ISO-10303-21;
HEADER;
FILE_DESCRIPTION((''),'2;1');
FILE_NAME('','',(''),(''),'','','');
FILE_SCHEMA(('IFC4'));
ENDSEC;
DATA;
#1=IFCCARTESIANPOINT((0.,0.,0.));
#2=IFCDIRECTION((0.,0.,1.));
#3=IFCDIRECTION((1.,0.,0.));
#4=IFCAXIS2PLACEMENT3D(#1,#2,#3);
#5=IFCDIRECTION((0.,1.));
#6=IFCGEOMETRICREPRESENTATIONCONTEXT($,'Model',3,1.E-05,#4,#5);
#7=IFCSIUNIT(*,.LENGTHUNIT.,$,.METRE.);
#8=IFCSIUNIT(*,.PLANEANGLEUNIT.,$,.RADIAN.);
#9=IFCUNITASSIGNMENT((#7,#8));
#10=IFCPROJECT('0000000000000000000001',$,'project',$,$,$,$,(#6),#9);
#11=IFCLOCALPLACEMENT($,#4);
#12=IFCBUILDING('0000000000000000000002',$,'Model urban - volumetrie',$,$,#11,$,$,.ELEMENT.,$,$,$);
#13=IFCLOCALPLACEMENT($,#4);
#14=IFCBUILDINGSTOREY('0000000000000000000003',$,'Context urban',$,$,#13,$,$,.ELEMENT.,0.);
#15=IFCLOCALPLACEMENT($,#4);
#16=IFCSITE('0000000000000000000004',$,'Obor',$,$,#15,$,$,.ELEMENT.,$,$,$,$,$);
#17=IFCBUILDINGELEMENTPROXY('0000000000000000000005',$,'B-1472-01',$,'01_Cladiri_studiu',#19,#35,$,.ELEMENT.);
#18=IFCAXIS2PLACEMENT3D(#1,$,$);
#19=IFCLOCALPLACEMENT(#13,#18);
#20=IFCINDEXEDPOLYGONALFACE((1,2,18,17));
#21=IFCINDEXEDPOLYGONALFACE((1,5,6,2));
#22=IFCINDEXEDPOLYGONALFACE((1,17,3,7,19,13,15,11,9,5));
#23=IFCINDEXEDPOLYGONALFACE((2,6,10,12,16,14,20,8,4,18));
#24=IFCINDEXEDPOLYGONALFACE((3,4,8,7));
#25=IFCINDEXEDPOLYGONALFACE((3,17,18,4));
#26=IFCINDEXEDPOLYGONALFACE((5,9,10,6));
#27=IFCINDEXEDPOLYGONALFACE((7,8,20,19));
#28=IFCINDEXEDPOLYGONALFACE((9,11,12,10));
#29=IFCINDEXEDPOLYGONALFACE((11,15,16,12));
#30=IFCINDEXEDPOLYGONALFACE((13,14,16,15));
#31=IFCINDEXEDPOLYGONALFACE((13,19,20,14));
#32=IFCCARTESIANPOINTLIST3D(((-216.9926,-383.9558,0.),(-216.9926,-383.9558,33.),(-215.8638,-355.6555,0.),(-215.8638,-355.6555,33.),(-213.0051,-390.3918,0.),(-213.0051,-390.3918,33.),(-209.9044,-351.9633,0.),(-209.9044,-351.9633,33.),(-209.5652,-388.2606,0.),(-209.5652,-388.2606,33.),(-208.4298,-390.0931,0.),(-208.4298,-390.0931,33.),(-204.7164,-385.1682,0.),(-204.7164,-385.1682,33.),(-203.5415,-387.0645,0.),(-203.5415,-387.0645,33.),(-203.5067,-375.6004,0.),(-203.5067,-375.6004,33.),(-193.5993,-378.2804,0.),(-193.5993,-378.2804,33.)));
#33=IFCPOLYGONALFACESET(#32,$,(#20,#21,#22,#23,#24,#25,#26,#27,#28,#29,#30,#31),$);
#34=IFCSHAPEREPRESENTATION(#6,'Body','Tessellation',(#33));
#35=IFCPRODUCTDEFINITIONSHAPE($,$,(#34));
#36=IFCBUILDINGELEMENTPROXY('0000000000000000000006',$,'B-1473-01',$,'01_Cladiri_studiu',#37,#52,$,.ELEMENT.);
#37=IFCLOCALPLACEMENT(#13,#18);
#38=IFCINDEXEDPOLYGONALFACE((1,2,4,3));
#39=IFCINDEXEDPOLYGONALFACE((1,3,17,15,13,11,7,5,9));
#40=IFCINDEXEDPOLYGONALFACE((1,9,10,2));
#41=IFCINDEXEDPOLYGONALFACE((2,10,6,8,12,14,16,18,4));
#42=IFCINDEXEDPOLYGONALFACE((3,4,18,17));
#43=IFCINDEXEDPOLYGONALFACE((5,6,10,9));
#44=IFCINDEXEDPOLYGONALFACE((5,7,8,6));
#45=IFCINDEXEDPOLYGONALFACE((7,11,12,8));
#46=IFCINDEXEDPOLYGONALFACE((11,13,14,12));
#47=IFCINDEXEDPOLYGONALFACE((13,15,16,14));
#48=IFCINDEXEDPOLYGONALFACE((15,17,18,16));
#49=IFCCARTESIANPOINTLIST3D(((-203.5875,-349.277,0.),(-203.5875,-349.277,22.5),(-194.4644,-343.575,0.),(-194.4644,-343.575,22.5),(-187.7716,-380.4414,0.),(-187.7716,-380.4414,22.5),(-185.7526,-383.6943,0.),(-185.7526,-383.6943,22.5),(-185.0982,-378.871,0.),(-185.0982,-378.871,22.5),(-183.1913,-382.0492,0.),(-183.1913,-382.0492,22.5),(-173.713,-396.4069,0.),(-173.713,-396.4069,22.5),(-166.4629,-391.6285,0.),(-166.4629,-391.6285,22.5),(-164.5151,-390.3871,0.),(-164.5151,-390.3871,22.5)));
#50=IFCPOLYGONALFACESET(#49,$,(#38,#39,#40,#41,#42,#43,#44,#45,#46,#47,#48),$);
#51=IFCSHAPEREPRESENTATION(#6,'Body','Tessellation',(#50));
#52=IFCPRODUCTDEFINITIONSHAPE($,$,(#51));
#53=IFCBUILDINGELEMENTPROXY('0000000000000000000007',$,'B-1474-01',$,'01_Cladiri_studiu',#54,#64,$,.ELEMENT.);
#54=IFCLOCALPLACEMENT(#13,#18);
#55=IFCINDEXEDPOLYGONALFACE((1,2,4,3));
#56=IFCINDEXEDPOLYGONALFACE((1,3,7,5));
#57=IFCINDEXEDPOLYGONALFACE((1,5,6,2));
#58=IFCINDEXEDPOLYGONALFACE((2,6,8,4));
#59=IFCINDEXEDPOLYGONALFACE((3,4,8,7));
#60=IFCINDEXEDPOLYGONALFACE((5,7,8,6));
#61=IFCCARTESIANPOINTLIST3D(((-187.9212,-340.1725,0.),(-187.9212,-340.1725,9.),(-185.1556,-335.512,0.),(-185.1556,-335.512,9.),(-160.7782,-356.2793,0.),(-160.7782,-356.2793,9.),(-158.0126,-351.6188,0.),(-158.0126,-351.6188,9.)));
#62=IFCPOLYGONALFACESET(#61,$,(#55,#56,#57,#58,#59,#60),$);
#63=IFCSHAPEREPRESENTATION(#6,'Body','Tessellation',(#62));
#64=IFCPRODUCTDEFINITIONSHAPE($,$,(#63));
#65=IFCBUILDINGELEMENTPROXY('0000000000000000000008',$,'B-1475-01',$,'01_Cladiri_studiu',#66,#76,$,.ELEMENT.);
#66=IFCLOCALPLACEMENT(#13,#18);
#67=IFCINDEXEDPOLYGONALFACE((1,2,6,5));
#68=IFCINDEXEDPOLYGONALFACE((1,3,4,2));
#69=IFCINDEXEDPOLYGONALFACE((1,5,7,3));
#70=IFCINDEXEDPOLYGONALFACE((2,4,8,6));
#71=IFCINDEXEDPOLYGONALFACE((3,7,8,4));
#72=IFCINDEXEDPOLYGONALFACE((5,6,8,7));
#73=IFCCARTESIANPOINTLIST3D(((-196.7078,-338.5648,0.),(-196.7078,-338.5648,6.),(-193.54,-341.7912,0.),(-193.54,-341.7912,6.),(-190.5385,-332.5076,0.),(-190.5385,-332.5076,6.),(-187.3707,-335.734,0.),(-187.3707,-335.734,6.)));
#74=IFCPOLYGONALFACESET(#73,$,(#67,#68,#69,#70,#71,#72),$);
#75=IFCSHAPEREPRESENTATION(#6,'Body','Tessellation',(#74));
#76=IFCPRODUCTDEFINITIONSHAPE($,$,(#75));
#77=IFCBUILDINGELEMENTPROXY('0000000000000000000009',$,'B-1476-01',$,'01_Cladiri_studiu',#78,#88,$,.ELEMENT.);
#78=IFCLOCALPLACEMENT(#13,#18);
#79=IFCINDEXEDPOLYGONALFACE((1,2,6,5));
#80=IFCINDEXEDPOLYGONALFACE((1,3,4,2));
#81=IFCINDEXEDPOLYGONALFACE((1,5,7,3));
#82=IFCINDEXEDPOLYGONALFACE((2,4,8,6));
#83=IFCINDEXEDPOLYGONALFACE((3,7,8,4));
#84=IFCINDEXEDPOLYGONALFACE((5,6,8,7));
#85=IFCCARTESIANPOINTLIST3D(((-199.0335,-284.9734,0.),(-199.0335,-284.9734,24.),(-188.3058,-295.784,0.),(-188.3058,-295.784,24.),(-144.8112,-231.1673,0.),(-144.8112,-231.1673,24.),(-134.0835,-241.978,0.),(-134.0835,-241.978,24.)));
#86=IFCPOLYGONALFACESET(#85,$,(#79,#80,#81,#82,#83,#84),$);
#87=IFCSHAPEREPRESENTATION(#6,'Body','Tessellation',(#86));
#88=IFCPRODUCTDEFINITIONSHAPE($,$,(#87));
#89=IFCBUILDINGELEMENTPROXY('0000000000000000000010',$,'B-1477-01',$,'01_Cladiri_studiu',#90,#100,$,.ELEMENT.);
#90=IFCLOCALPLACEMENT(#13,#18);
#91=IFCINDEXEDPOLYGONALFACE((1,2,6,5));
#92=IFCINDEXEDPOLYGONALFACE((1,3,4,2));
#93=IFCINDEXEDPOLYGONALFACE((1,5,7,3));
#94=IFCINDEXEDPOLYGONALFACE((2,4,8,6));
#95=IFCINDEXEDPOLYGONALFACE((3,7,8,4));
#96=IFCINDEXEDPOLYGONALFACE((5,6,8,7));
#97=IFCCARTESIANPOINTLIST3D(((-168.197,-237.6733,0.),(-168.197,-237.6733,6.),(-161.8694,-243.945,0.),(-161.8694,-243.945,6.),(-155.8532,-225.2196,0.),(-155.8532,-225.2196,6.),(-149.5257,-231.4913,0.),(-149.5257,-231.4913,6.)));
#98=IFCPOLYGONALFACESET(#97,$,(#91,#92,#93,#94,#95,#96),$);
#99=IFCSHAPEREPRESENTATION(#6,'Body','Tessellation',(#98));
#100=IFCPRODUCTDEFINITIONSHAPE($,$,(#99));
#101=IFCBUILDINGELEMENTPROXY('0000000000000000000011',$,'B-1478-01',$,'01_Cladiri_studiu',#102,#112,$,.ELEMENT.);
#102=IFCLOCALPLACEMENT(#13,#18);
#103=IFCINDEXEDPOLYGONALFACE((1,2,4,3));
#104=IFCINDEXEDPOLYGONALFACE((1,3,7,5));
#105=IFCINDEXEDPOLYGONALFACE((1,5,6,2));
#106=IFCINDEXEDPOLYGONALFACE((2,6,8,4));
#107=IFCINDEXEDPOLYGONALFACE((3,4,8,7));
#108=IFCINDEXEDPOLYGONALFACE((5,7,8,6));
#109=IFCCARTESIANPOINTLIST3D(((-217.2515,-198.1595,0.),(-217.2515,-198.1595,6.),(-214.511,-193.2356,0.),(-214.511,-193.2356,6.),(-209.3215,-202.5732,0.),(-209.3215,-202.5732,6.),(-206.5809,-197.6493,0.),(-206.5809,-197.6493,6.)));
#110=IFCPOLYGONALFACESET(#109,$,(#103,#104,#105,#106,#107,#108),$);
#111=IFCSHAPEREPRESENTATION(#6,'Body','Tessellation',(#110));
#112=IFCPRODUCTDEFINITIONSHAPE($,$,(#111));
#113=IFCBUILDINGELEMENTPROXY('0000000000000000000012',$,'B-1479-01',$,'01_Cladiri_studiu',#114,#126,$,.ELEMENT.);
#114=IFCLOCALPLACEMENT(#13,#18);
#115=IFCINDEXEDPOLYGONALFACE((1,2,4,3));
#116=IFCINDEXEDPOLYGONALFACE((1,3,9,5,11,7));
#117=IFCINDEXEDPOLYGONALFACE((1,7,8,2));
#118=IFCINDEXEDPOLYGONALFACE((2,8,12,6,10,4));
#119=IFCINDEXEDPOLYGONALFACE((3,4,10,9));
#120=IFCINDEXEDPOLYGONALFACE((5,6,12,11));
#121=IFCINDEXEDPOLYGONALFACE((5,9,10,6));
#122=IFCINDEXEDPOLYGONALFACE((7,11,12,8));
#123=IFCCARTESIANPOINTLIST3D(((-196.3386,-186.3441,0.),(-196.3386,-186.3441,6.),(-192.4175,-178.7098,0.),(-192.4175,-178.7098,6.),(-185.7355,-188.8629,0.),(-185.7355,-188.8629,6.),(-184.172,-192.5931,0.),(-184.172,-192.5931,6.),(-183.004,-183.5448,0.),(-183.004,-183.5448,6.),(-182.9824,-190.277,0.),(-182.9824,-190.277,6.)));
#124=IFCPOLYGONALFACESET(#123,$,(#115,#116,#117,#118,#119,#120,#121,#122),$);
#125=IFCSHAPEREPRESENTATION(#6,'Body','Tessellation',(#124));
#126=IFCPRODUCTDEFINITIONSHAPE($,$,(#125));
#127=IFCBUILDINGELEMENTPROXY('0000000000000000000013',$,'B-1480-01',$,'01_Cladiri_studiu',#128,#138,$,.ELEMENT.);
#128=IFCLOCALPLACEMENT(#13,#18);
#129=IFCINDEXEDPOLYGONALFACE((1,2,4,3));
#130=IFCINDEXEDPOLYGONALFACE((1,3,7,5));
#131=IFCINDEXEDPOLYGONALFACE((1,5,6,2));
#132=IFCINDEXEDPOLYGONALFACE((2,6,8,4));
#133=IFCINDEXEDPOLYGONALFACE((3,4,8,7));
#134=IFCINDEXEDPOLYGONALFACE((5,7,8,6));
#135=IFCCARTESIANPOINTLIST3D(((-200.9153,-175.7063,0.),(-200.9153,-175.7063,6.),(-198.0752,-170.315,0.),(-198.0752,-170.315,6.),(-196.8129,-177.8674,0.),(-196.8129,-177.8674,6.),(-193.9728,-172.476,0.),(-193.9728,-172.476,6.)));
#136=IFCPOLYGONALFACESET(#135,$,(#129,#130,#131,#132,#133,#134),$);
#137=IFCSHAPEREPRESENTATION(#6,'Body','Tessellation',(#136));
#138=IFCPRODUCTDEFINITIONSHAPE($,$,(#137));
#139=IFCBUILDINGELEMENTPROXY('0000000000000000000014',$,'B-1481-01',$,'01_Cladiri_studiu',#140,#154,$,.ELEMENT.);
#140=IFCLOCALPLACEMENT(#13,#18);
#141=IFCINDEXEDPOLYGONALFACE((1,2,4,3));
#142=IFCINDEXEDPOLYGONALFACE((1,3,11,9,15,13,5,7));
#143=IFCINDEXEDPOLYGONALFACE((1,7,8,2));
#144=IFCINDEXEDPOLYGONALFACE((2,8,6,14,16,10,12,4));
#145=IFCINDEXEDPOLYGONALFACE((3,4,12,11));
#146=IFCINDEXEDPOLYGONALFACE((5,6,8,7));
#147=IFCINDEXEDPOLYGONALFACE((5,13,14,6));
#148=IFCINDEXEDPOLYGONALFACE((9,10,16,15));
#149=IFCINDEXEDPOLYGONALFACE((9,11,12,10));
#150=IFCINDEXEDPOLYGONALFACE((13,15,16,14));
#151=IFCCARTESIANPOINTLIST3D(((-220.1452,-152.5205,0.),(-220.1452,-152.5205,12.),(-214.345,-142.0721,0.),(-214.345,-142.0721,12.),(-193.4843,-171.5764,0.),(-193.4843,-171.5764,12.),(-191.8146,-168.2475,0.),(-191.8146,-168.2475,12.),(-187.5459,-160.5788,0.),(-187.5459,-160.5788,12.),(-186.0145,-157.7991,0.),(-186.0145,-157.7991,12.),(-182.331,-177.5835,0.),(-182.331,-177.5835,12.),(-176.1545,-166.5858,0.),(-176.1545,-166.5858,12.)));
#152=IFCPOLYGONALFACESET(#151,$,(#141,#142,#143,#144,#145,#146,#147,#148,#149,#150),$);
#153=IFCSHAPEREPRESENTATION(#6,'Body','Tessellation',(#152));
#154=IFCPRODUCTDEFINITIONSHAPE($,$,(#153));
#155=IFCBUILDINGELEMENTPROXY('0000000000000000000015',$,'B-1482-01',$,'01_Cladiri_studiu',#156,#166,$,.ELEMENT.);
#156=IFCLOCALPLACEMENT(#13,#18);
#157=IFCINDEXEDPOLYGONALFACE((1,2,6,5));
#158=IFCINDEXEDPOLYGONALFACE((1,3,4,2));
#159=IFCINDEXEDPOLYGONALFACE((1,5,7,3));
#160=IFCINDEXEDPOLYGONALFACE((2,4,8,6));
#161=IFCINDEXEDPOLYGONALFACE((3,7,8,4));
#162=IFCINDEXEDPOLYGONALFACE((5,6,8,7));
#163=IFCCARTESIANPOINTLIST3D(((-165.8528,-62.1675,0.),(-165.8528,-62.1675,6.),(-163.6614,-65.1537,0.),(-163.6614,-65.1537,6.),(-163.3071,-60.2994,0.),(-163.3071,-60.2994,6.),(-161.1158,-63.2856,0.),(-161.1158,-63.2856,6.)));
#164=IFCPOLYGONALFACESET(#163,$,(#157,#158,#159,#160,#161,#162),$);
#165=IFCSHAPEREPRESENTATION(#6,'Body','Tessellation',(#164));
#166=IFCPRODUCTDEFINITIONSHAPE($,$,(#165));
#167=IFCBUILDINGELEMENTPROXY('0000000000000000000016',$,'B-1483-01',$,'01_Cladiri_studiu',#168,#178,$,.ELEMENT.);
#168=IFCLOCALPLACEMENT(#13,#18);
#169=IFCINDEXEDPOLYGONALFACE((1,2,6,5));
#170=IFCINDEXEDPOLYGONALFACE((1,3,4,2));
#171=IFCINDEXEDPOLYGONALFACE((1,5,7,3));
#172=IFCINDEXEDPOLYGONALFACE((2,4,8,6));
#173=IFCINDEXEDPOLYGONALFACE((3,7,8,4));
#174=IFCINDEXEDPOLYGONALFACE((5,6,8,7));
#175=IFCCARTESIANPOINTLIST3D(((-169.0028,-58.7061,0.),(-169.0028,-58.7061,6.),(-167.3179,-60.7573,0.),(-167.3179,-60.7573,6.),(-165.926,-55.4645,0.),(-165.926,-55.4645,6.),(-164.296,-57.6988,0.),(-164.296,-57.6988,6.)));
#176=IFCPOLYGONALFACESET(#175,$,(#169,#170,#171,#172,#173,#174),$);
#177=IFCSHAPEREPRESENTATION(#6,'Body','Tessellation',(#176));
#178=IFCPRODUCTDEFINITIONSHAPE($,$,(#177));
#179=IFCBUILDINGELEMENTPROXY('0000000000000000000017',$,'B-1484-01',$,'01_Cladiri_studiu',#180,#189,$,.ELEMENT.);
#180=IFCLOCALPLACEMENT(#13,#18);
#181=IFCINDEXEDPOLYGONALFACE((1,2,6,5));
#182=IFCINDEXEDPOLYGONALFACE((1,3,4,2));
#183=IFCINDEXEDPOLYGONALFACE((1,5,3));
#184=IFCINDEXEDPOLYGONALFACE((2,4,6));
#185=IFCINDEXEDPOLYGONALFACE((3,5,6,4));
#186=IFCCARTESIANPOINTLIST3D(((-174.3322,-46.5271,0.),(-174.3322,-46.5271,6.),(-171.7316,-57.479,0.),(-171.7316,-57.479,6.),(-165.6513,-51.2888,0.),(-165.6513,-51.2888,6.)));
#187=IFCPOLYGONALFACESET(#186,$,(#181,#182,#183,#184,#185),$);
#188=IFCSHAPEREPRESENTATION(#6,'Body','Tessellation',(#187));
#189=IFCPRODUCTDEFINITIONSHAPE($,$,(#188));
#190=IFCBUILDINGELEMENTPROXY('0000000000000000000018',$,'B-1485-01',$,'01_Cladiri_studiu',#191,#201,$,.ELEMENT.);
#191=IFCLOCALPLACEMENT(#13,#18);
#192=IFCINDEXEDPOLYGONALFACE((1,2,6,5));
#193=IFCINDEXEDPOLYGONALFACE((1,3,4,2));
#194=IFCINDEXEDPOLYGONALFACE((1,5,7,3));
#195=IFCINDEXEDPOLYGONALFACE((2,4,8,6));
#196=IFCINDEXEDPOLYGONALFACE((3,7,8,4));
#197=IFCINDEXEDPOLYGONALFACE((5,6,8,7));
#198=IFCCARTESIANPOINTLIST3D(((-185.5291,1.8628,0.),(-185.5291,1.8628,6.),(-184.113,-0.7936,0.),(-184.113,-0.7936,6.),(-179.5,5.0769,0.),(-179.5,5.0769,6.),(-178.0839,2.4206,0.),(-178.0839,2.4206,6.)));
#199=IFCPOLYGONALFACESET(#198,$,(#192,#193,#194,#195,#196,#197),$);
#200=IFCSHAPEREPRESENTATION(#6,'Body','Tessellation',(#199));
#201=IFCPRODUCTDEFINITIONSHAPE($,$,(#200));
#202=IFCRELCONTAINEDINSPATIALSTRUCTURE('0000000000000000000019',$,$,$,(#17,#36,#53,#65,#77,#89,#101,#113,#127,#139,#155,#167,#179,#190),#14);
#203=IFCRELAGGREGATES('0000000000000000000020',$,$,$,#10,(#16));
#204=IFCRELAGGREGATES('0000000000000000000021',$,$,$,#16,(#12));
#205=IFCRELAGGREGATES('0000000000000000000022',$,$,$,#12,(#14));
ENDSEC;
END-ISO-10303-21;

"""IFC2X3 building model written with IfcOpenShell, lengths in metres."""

from ifc_helpers import new_model, si_unit, direction, origin_with_axes, place, context, project, spatial, polyline, outline, extrude, element, save


model = new_model("IFC2X3")

# Units and contexts
model_context = context("Model", 3, precision=1e-05, world=origin_with_axes(), true_north=direction((0.0, 1.0)))
ifc_project = project(units=[si_unit("LENGTHUNIT", "METRE"), si_unit("PLANEANGLEUNIT", "RADIAN")], contexts=[model_context])

# Site, building, storey
site_placement = place(None, origin_with_axes())
site = spatial("IfcSite", under=ifc_project, at=site_placement, Name="Obor", CompositionType="ELEMENT")
building_placement = place(None, origin_with_axes())
building = spatial("IfcBuilding", under=site, at=building_placement, Name="Model urban - volumetrie", CompositionType="ELEMENT")
storey_placement = place(None, origin_with_axes())
storey = spatial("IfcBuildingStorey", under=building, at=storey_placement, Name="Context urban", CompositionType="ELEMENT", Elevation=0.0)

# Building element proxies
proxy_1_placement = place(None, origin_with_axes())
element("IfcBuildingElementProxy", 1, at=proxy_1_placement, inside=storey, Name="B-1472-01", ObjectType="01_Cladiri_studiu", CompositionType="ELEMENT", context=model_context, shape_type="SweptSolid", body=[
    extrude(outline(polyline([(-204.7164, -385.1682), (-193.5993, -378.2804), (-209.9044, -351.9633), (-215.8638, -355.6555), (-203.5067, -375.6004), (-216.9926, -383.9558), (-213.0051, -390.3918), (-209.5652, -388.2606), (-208.4298, -390.0931), (-203.5415, -387.0645), (-204.7164, -385.1682)])), origin_with_axes(), (0.0, 0.0, 1.0), 33.0),
])
proxy_2_placement = place(None, origin_with_axes())
element("IfcBuildingElementProxy", 2, at=proxy_2_placement, inside=storey, Name="B-1473-01", ObjectType="01_Cladiri_studiu", CompositionType="ELEMENT", context=model_context, shape_type="SweptSolid", body=[
    extrude(outline(polyline([(-203.5875, -349.277), (-185.0982, -378.871), (-187.7716, -380.4414), (-185.7526, -383.6943), (-183.1913, -382.0492), (-173.713, -396.4069), (-166.4629, -391.6285), (-164.5151, -390.3871), (-194.4644, -343.575), (-203.5875, -349.277)])), origin_with_axes(), (0.0, 0.0, 1.0), 22.5),
])
proxy_3_placement = place(None, origin_with_axes())
element("IfcBuildingElementProxy", 3, at=proxy_3_placement, inside=storey, Name="B-1474-01", ObjectType="01_Cladiri_studiu", CompositionType="ELEMENT", context=model_context, shape_type="SweptSolid", body=[
    extrude(outline(polyline([(-160.7782, -356.2793), (-158.0126, -351.6188), (-185.1556, -335.512), (-187.9212, -340.1725), (-160.7782, -356.2793)])), origin_with_axes(), (0.0, 0.0, 1.0), 9.0),
])
proxy_4_placement = place(None, origin_with_axes())
element("IfcBuildingElementProxy", 4, at=proxy_4_placement, inside=storey, Name="B-1475-01", ObjectType="01_Cladiri_studiu", CompositionType="ELEMENT", context=model_context, shape_type="SweptSolid", body=[
    extrude(outline(polyline([(-193.54, -341.7912), (-187.3707, -335.734), (-190.5385, -332.5076), (-196.7078, -338.5648), (-193.54, -341.7912)])), origin_with_axes(), (0.0, 0.0, 1.0), 6.0),
])
proxy_5_placement = place(None, origin_with_axes())
element("IfcBuildingElementProxy", 5, at=proxy_5_placement, inside=storey, Name="B-1476-01", ObjectType="01_Cladiri_studiu", CompositionType="ELEMENT", context=model_context, shape_type="SweptSolid", body=[
    extrude(outline(polyline([(-144.8112, -231.1673), (-199.0335, -284.9734), (-188.3058, -295.784), (-134.0835, -241.978), (-144.8112, -231.1673)])), origin_with_axes(), (0.0, 0.0, 1.0), 24.0),
])
proxy_6_placement = place(None, origin_with_axes())
element("IfcBuildingElementProxy", 6, at=proxy_6_placement, inside=storey, Name="B-1477-01", ObjectType="01_Cladiri_studiu", CompositionType="ELEMENT", context=model_context, shape_type="SweptSolid", body=[
    extrude(outline(polyline([(-155.8532, -225.2196), (-168.197, -237.6733), (-161.8694, -243.945), (-149.5257, -231.4913), (-155.8532, -225.2196)])), origin_with_axes(), (0.0, 0.0, 1.0), 6.0),
])
proxy_7_placement = place(None, origin_with_axes())
element("IfcBuildingElementProxy", 7, at=proxy_7_placement, inside=storey, Name="B-1478-01", ObjectType="01_Cladiri_studiu", CompositionType="ELEMENT", context=model_context, shape_type="SweptSolid", body=[
    extrude(outline(polyline([(-209.3215, -202.5732), (-206.5809, -197.6493), (-214.511, -193.2356), (-217.2515, -198.1595), (-209.3215, -202.5732)])), origin_with_axes(), (0.0, 0.0, 1.0), 6.0),
])
proxy_8_placement = place(None, origin_with_axes())
element("IfcBuildingElementProxy", 8, at=proxy_8_placement, inside=storey, Name="B-1479-01", ObjectType="01_Cladiri_studiu", CompositionType="ELEMENT", context=model_context, shape_type="SweptSolid", body=[
    extrude(outline(polyline([(-182.9824, -190.277), (-185.7355, -188.8629), (-183.004, -183.5448), (-192.4175, -178.7098), (-196.3386, -186.3441), (-184.172, -192.5931), (-182.9824, -190.277)])), origin_with_axes(), (0.0, 0.0, 1.0), 6.0),
])
proxy_9_placement = place(None, origin_with_axes())
element("IfcBuildingElementProxy", 9, at=proxy_9_placement, inside=storey, Name="B-1480-01", ObjectType="01_Cladiri_studiu", CompositionType="ELEMENT", context=model_context, shape_type="SweptSolid", body=[
    extrude(outline(polyline([(-193.9728, -172.476), (-198.0752, -170.315), (-200.9153, -175.7063), (-196.8129, -177.8674), (-193.9728, -172.476)])), origin_with_axes(), (0.0, 0.0, 1.0), 6.0),
])
proxy_10_placement = place(None, origin_with_axes())
element("IfcBuildingElementProxy", 10, at=proxy_10_placement, inside=storey, Name="B-1481-01", ObjectType="01_Cladiri_studiu", CompositionType="ELEMENT", context=model_context, shape_type="SweptSolid", body=[
    extrude(outline(polyline([(-220.1452, -152.5205), (-191.8146, -168.2475), (-193.4843, -171.5764), (-182.331, -177.5835), (-176.1545, -166.5858), (-187.5459, -160.5788), (-186.0145, -157.7991), (-214.345, -142.0721), (-220.1452, -152.5205)])), origin_with_axes(), (0.0, 0.0, 1.0), 12.0),
])
proxy_11_placement = place(None, origin_with_axes())
element("IfcBuildingElementProxy", 11, at=proxy_11_placement, inside=storey, Name="B-1482-01", ObjectType="01_Cladiri_studiu", CompositionType="ELEMENT", context=model_context, shape_type="SweptSolid", body=[
    extrude(outline(polyline([(-163.6614, -65.1537), (-161.1158, -63.2856), (-163.3071, -60.2994), (-165.8528, -62.1675), (-163.6614, -65.1537)])), origin_with_axes(), (0.0, 0.0, 1.0), 6.0),
])
proxy_12_placement = place(None, origin_with_axes())
element("IfcBuildingElementProxy", 12, at=proxy_12_placement, inside=storey, Name="B-1483-01", ObjectType="01_Cladiri_studiu", CompositionType="ELEMENT", context=model_context, shape_type="SweptSolid", body=[
    extrude(outline(polyline([(-167.3179, -60.7573), (-164.296, -57.6988), (-165.926, -55.4645), (-169.0028, -58.7061), (-167.3179, -60.7573)])), origin_with_axes(), (0.0, 0.0, 1.0), 6.0),
])
proxy_13_placement = place(None, origin_with_axes())
element("IfcBuildingElementProxy", 13, at=proxy_13_placement, inside=storey, Name="B-1484-01", ObjectType="01_Cladiri_studiu", CompositionType="ELEMENT", context=model_context, shape_type="SweptSolid", body=[
    extrude(outline(polyline([(-171.7316, -57.479), (-165.6513, -51.2888), (-174.3322, -46.5271), (-171.7316, -57.479)])), origin_with_axes(), (0.0, 0.0, 1.0), 6.0),
])
proxy_14_placement = place(None, origin_with_axes())
element("IfcBuildingElementProxy", 14, at=proxy_14_placement, inside=storey, Name="B-1485-01", ObjectType="01_Cladiri_studiu", CompositionType="ELEMENT", context=model_context, shape_type="SweptSolid", body=[
    extrude(outline(polyline([(-178.0839, 2.4206), (-179.5, 5.0769), (-185.5291, 1.8628), (-184.113, -0.7936), (-178.0839, 2.4206)])), origin_with_axes(), (0.0, 0.0, 1.0), 6.0),
])

save(model, "model.ifc")
